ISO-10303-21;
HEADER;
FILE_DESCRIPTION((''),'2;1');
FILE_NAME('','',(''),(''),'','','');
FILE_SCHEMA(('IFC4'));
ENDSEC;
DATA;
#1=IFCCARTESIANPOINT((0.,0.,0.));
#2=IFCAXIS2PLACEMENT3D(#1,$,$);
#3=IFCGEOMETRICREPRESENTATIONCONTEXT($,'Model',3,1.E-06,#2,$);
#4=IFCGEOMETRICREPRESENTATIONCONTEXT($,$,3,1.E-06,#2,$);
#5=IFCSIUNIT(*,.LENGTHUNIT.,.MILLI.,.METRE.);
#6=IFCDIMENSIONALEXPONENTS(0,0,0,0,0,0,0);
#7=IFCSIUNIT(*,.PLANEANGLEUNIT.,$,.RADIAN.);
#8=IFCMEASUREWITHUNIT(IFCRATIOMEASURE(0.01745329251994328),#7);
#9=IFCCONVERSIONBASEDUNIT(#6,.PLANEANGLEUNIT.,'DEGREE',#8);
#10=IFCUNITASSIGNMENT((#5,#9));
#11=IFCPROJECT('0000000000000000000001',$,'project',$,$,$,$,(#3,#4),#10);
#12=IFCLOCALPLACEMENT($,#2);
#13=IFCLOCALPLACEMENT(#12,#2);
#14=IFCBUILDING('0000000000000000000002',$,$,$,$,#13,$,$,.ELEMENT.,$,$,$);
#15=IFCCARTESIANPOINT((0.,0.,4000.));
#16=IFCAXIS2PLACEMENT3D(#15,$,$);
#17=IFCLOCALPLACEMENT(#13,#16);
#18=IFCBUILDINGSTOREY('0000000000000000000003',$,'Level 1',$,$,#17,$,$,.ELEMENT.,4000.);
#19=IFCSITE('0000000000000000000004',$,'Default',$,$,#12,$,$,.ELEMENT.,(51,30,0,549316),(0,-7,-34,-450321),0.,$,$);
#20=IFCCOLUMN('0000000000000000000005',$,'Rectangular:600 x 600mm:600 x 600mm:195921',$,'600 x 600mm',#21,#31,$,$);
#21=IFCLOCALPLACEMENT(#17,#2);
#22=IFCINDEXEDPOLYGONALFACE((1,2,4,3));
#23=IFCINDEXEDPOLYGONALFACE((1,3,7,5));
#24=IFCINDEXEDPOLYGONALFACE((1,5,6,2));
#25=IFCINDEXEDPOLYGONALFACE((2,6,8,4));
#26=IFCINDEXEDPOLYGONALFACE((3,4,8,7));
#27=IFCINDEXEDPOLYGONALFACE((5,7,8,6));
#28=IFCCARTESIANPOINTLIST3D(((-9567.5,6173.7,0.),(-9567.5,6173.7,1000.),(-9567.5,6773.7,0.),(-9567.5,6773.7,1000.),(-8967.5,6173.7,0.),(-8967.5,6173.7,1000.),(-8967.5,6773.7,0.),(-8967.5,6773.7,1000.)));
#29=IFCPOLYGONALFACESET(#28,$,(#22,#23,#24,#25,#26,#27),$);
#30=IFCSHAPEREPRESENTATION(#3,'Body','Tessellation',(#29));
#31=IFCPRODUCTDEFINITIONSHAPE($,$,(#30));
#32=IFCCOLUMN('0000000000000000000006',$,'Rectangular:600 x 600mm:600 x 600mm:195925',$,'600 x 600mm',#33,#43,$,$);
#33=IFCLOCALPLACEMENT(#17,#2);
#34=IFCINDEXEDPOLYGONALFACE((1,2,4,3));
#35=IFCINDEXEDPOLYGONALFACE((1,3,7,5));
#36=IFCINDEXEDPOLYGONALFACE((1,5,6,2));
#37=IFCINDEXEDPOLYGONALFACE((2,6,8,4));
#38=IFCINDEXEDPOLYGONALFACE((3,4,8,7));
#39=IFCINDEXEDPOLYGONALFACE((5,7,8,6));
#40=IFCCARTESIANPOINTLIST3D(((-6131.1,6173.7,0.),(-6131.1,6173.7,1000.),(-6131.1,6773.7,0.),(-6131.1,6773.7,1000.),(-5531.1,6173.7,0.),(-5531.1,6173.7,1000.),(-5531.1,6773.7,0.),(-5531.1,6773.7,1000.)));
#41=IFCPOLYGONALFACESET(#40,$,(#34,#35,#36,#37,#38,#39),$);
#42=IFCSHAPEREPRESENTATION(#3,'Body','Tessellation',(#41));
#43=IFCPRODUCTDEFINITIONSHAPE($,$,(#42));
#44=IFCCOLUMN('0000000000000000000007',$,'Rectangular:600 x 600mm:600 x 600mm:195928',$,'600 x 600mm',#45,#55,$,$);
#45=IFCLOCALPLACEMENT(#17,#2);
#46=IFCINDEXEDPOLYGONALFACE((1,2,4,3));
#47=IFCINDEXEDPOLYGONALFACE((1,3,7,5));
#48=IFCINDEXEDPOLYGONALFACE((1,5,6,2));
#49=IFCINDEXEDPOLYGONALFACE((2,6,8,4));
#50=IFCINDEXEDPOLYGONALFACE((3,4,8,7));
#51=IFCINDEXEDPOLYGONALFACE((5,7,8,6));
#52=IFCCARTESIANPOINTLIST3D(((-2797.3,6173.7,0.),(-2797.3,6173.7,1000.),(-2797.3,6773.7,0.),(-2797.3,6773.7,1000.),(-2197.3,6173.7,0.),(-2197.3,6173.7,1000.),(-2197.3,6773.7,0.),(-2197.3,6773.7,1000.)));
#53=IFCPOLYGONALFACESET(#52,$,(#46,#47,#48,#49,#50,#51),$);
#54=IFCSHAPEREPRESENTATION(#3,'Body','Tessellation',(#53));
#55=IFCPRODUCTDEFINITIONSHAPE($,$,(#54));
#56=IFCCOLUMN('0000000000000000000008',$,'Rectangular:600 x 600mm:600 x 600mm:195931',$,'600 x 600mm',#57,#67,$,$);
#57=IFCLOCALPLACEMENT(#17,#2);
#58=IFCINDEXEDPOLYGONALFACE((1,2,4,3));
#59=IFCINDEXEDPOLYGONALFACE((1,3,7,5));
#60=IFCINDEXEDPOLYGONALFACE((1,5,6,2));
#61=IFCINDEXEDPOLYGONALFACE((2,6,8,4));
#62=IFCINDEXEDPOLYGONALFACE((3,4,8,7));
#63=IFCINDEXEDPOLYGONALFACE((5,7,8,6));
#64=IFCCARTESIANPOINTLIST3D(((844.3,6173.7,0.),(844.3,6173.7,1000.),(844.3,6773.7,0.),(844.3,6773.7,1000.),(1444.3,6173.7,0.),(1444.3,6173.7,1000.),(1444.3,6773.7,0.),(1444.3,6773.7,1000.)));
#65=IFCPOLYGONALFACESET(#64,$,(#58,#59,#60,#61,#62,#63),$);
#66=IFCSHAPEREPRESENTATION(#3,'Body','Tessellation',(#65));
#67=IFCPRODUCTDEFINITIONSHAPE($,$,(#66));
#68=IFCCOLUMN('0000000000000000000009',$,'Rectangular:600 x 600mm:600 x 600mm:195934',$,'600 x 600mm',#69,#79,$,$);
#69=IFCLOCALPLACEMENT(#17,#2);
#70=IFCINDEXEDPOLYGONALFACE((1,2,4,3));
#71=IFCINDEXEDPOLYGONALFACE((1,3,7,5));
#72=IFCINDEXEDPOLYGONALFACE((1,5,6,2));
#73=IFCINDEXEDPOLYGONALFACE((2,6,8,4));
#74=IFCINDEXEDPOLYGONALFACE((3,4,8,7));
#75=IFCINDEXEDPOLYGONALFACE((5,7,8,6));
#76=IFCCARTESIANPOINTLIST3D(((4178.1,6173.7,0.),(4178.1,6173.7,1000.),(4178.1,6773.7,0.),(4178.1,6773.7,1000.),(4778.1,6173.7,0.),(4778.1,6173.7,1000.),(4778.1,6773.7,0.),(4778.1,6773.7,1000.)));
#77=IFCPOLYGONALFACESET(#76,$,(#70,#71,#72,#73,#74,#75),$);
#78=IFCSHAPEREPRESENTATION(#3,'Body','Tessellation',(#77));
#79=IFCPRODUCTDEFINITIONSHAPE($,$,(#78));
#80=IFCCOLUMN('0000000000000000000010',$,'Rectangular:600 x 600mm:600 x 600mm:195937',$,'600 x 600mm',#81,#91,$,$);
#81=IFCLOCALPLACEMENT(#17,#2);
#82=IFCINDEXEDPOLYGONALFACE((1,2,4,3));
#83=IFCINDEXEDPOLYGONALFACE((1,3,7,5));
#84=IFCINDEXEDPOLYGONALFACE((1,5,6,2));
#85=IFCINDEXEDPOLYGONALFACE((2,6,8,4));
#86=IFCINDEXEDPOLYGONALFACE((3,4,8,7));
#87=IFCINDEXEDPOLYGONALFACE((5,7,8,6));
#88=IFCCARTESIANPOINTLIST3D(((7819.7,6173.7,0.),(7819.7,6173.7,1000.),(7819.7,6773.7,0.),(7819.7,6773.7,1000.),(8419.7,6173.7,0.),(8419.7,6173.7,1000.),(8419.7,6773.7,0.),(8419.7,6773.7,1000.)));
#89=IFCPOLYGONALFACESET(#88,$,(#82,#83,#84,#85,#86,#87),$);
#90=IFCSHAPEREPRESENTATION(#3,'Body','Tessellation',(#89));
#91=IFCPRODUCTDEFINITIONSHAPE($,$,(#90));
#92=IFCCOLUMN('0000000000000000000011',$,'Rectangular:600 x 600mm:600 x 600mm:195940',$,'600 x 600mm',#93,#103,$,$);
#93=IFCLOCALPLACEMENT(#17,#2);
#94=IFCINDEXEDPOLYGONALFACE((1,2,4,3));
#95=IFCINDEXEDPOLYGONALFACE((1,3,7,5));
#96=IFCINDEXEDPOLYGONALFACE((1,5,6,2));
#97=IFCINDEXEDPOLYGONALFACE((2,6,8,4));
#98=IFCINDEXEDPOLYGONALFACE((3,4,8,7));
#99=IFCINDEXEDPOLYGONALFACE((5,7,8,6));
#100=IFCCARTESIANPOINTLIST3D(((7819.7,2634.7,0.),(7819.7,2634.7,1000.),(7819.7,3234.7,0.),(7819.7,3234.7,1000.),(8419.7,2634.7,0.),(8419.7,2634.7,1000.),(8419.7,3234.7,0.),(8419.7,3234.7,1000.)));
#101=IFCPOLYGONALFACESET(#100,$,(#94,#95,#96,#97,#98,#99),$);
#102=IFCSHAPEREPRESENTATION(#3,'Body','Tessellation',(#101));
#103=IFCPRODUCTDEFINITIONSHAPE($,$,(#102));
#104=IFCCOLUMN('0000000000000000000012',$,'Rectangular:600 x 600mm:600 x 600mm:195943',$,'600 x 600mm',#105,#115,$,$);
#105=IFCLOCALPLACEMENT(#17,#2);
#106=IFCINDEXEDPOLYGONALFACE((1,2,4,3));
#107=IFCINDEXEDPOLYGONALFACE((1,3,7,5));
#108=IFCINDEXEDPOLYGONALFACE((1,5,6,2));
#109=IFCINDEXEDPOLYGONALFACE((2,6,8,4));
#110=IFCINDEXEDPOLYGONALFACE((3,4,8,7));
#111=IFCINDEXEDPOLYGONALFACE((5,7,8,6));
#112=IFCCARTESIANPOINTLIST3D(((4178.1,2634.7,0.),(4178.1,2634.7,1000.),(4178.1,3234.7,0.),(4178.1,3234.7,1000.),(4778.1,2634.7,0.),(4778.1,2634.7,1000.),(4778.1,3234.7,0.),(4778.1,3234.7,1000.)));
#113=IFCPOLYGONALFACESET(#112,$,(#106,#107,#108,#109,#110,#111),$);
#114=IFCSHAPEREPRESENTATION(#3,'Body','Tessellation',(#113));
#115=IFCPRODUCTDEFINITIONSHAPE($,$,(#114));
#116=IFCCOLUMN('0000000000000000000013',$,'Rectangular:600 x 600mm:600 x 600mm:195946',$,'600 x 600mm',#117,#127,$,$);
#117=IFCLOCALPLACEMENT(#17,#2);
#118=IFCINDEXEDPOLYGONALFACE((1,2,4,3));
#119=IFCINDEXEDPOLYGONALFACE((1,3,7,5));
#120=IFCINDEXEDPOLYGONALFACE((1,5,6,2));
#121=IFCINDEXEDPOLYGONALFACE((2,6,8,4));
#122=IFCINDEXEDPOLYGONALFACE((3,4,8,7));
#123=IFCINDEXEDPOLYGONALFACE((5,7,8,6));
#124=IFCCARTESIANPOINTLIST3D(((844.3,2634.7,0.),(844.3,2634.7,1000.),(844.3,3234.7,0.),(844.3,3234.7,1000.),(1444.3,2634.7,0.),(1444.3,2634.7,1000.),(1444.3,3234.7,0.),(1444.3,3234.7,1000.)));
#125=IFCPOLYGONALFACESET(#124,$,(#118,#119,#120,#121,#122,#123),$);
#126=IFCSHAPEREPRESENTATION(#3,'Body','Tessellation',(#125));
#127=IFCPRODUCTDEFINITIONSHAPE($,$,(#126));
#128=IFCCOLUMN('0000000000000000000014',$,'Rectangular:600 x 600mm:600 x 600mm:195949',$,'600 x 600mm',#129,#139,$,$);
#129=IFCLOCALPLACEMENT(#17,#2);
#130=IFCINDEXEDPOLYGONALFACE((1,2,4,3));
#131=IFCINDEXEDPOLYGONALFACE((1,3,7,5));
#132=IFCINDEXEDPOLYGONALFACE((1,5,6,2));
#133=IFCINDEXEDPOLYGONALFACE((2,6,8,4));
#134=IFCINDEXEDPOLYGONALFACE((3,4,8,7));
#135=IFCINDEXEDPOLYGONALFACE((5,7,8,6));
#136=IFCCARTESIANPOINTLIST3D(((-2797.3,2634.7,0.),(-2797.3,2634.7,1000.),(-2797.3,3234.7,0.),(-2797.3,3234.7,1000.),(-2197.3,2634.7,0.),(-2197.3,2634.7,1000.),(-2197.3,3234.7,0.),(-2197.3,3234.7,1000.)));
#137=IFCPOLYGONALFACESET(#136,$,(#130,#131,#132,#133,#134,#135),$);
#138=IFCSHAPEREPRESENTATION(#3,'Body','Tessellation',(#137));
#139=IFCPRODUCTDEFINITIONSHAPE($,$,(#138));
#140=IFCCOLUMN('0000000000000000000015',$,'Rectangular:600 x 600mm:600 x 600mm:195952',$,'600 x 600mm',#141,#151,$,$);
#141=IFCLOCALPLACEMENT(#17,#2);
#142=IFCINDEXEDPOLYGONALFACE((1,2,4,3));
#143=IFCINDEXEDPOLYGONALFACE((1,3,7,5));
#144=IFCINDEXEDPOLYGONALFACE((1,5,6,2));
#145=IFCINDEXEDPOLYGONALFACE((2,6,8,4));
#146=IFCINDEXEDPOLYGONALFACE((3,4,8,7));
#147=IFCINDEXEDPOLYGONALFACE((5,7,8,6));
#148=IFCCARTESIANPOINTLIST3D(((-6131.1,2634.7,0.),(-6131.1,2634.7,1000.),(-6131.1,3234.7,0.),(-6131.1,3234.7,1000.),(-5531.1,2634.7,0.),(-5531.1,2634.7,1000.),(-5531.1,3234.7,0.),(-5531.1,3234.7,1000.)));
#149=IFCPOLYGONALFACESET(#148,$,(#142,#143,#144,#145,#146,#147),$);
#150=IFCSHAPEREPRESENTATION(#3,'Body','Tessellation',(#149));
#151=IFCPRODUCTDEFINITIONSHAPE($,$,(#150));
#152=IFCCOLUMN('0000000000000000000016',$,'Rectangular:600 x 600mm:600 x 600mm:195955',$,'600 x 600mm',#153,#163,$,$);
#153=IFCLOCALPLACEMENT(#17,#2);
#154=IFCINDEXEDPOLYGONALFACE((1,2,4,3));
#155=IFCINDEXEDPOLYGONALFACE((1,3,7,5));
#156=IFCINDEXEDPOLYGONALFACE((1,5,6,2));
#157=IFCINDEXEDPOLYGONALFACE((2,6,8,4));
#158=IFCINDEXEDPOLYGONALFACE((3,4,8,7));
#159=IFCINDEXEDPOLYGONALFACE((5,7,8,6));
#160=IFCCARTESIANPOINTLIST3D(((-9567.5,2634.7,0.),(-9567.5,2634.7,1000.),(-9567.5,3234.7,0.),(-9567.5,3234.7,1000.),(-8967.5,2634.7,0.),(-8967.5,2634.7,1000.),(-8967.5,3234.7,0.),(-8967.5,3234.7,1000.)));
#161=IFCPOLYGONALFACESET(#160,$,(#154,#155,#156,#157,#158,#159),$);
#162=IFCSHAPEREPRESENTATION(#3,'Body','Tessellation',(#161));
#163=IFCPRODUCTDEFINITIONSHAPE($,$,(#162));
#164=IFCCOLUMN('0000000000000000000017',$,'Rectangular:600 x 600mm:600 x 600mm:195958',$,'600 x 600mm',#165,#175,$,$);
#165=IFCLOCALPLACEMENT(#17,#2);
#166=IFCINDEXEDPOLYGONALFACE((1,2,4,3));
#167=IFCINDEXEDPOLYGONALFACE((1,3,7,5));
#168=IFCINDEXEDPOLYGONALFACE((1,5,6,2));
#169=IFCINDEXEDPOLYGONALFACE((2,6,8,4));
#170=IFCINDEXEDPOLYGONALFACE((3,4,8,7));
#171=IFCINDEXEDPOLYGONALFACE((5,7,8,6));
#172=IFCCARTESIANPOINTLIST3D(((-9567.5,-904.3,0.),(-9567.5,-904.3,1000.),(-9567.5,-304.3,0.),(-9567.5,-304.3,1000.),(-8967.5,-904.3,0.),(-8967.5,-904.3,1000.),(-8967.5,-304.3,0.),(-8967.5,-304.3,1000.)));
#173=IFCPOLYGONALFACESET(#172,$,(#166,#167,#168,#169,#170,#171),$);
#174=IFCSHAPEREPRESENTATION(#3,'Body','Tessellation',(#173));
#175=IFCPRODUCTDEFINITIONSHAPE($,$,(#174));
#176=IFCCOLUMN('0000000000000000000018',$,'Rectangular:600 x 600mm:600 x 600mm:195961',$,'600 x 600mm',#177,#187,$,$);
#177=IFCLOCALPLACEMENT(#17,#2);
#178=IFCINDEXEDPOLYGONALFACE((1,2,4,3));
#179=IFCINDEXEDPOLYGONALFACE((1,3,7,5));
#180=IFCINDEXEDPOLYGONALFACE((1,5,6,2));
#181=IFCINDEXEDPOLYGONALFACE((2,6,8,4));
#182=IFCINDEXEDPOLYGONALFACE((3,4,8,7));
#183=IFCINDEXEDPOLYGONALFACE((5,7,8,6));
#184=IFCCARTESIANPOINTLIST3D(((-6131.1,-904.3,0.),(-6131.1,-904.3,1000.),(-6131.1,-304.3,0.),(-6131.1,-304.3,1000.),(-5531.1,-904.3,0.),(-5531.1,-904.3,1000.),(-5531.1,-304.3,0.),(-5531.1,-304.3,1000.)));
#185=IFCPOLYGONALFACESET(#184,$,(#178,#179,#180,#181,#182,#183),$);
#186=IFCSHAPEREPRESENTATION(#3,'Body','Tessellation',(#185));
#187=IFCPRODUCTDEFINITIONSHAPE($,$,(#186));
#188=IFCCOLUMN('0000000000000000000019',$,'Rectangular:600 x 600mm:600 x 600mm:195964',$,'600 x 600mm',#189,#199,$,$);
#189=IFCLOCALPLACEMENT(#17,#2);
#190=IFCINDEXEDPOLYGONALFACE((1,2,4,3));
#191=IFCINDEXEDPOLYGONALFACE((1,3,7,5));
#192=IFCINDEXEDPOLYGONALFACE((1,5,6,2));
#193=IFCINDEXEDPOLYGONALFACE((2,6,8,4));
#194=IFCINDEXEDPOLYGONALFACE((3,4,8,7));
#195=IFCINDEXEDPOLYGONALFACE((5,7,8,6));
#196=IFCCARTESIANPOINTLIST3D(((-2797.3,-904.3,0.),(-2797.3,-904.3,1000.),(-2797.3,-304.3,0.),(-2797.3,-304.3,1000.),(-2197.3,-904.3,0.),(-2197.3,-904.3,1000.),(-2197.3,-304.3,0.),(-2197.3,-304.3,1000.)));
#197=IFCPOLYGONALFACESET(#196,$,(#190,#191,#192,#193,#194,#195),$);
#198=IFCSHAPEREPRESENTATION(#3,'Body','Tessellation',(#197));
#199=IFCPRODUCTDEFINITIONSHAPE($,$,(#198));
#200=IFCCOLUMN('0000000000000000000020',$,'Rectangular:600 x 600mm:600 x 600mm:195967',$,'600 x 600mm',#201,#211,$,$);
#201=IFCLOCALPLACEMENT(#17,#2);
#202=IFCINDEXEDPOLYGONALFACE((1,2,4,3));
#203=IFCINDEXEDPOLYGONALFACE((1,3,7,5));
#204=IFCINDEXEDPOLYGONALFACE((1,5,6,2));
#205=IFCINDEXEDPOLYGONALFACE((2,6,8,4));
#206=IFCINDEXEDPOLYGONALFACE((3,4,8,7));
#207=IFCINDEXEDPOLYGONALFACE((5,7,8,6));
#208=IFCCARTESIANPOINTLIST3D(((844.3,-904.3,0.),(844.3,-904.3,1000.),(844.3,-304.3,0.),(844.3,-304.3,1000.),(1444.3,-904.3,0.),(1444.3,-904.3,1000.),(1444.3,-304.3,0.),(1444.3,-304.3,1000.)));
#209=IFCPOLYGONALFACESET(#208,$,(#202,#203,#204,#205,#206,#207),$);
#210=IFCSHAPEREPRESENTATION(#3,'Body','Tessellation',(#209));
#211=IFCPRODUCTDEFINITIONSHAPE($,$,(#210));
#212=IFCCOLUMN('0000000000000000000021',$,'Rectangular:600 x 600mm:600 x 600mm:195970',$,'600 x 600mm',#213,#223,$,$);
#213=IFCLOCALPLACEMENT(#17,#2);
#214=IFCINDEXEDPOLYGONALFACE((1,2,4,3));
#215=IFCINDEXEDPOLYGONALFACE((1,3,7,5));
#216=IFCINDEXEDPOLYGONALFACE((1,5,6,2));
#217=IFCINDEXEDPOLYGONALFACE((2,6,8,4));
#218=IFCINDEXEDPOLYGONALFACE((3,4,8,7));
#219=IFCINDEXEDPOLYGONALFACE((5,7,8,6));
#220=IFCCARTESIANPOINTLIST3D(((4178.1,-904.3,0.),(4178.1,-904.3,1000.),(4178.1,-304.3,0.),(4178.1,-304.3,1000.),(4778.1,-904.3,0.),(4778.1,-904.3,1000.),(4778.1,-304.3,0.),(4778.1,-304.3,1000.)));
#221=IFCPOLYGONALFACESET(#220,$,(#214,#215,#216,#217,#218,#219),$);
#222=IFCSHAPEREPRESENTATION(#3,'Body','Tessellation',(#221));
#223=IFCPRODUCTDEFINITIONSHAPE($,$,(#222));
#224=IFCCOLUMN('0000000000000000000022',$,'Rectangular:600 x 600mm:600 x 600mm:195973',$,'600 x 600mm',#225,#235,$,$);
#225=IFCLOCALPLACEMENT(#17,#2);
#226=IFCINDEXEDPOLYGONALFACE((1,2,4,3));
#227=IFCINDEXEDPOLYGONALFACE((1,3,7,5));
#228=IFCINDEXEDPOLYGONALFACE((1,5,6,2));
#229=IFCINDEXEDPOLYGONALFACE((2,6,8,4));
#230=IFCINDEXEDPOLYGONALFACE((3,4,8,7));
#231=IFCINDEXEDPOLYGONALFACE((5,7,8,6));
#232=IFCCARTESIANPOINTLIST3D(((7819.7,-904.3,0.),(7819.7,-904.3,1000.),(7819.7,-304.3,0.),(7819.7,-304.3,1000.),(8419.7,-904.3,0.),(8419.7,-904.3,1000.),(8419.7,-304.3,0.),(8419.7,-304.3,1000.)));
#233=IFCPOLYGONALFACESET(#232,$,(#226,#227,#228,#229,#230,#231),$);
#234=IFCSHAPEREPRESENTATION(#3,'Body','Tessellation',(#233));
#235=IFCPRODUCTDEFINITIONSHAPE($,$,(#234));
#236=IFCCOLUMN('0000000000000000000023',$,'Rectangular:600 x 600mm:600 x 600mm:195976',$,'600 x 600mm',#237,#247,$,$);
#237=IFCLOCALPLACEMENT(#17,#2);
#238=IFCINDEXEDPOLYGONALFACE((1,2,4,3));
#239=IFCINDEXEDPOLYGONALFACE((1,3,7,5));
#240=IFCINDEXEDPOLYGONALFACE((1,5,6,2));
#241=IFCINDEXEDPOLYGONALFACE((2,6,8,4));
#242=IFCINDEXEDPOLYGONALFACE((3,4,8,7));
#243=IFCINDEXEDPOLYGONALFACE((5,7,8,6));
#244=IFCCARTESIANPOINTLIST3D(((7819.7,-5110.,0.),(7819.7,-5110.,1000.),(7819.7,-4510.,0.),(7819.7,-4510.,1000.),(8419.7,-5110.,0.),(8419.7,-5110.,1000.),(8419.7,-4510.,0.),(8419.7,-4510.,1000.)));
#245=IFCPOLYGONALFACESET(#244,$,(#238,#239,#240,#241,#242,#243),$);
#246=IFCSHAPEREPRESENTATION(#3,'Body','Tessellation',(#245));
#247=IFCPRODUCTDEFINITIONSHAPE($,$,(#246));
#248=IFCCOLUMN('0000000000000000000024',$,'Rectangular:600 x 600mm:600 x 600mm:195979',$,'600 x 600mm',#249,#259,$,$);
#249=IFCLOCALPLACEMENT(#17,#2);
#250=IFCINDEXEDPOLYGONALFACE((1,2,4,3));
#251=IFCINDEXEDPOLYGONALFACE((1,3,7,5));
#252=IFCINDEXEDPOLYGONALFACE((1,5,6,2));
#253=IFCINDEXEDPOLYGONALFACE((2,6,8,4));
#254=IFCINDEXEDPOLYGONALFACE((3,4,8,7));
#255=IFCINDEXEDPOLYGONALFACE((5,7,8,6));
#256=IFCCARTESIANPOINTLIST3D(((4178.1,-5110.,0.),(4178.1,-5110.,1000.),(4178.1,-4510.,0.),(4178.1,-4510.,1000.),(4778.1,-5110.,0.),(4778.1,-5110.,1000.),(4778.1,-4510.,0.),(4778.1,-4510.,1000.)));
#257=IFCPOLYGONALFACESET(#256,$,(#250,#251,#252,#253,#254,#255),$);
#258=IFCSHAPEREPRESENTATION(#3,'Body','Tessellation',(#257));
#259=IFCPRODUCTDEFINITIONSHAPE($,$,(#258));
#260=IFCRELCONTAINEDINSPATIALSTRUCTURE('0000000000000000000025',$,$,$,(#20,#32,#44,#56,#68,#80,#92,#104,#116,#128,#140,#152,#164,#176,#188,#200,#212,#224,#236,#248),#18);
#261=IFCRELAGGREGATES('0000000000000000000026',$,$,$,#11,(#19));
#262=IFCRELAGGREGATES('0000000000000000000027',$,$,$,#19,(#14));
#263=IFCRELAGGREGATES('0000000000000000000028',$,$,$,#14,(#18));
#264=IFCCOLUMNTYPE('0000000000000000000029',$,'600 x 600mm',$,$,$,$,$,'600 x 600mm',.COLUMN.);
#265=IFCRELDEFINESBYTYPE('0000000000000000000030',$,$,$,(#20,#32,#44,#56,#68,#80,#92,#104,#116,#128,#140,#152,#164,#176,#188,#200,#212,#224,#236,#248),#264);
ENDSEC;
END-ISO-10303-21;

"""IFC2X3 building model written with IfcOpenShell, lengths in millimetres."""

from ifc_helpers import new_model, entity, si_unit, converted_unit, frame, frame_2d, origin, place, context, project, spatial, rectangle, extrude, source, transform, mapped, type_object, type_shapes, element, save


model = new_model("IFC2X3")

# Units and contexts
model_context = context("Model", 3, precision=1e-06, world=origin())
context_of_model = context(None, 3, precision=1e-06, world=origin())
ifc_project = project(units=[si_unit("LENGTHUNIT", "METRE", prefix="MILLI"), converted_unit("PLANEANGLEUNIT", "DEGREE", entity("IfcRatioMeasure", 0.01745329251994328), si_unit("PLANEANGLEUNIT", "RADIAN"), dimensions=[0, 0, 0, 0, 0, 0, 0])], contexts=[model_context, context_of_model])

# Site, building, storey
site_placement = place(None, origin())
site = spatial("IfcSite", under=ifc_project, at=site_placement, Name="Default", CompositionType="ELEMENT", RefLatitude=(51, 30, 0, 549316), RefLongitude=(0, -7, -34, -450321), RefElevation=0.0)
building_placement = place(site_placement, origin())
building = spatial("IfcBuilding", under=site, at=building_placement, CompositionType="ELEMENT")
storey_placement = place(building_placement, frame((0.0, 0.0, 4000.0)))
storey = spatial("IfcBuildingStorey", under=building, at=storey_placement, Name="Level 1", CompositionType="ELEMENT", Elevation=4000.0)

# Columns
column_type = type_object("IfcColumnType", Name="600 x 600mm", ElementType="600 x 600mm", PredefinedType="COLUMN")
shared_shape = source(origin(), model_context, "Body", "SweptSolid", [
    extrude(rectangle(XDim=600.0, YDim=600.0, at=frame_2d((0.0, 0.0), x_axis=(0.0, -1.0))), origin(), (0.0, 0.0, 1.0), 1000.0),
])
type_shapes(column_type, [shared_shape])
for number, where, name in (
    (1, (-9267.5, 6473.7, 0.0), "Rectangular:600 x 600mm:600 x 600mm:195921"),
    (2, (-5831.1, 6473.7, 0.0), "Rectangular:600 x 600mm:600 x 600mm:195925"),
    (3, (-2497.3, 6473.7, 0.0), "Rectangular:600 x 600mm:600 x 600mm:195928"),
    (4, (1144.3, 6473.7, 0.0), "Rectangular:600 x 600mm:600 x 600mm:195931"),
    (5, (4478.1, 6473.7, 0.0), "Rectangular:600 x 600mm:600 x 600mm:195934"),
    (6, (8119.7, 6473.7, 0.0), "Rectangular:600 x 600mm:600 x 600mm:195937"),
    (7, (8119.7, 2934.7, 0.0), "Rectangular:600 x 600mm:600 x 600mm:195940"),
    (8, (4478.1, 2934.7, 0.0), "Rectangular:600 x 600mm:600 x 600mm:195943"),
    (9, (1144.3, 2934.7, 0.0), "Rectangular:600 x 600mm:600 x 600mm:195946"),
    (10, (-2497.3, 2934.7, 0.0), "Rectangular:600 x 600mm:600 x 600mm:195949"),
    (11, (-5831.1, 2934.7, 0.0), "Rectangular:600 x 600mm:600 x 600mm:195952"),
    (12, (-9267.5, 2934.7, 0.0), "Rectangular:600 x 600mm:600 x 600mm:195955"),
    (13, (-9267.5, -604.3, 0.0), "Rectangular:600 x 600mm:600 x 600mm:195958"),
    (14, (-5831.1, -604.3, 0.0), "Rectangular:600 x 600mm:600 x 600mm:195961"),
    (15, (-2497.3, -604.3, 0.0), "Rectangular:600 x 600mm:600 x 600mm:195964"),
    (16, (1144.3, -604.3, 0.0), "Rectangular:600 x 600mm:600 x 600mm:195967"),
    (17, (4478.1, -604.3, 0.0), "Rectangular:600 x 600mm:600 x 600mm:195970"),
    (18, (8119.7, -604.3, 0.0), "Rectangular:600 x 600mm:600 x 600mm:195973"),
    (19, (8119.7, -4810.0, 0.0), "Rectangular:600 x 600mm:600 x 600mm:195976"),
    (20, (4478.1, -4810.0, 0.0), "Rectangular:600 x 600mm:600 x 600mm:195979"),
):
    element("IfcColumn", number, at=place(storey_placement, frame(where)), inside=storey, type_object=column_type, Name=name, ObjectType="600 x 600mm", context=model_context, shape_type="MappedRepresentation", body=[
        mapped(shared_shape, transform((0.0, 0.0, 0.0), scale=1.0)),
    ])

save(model, "model.ifc")
